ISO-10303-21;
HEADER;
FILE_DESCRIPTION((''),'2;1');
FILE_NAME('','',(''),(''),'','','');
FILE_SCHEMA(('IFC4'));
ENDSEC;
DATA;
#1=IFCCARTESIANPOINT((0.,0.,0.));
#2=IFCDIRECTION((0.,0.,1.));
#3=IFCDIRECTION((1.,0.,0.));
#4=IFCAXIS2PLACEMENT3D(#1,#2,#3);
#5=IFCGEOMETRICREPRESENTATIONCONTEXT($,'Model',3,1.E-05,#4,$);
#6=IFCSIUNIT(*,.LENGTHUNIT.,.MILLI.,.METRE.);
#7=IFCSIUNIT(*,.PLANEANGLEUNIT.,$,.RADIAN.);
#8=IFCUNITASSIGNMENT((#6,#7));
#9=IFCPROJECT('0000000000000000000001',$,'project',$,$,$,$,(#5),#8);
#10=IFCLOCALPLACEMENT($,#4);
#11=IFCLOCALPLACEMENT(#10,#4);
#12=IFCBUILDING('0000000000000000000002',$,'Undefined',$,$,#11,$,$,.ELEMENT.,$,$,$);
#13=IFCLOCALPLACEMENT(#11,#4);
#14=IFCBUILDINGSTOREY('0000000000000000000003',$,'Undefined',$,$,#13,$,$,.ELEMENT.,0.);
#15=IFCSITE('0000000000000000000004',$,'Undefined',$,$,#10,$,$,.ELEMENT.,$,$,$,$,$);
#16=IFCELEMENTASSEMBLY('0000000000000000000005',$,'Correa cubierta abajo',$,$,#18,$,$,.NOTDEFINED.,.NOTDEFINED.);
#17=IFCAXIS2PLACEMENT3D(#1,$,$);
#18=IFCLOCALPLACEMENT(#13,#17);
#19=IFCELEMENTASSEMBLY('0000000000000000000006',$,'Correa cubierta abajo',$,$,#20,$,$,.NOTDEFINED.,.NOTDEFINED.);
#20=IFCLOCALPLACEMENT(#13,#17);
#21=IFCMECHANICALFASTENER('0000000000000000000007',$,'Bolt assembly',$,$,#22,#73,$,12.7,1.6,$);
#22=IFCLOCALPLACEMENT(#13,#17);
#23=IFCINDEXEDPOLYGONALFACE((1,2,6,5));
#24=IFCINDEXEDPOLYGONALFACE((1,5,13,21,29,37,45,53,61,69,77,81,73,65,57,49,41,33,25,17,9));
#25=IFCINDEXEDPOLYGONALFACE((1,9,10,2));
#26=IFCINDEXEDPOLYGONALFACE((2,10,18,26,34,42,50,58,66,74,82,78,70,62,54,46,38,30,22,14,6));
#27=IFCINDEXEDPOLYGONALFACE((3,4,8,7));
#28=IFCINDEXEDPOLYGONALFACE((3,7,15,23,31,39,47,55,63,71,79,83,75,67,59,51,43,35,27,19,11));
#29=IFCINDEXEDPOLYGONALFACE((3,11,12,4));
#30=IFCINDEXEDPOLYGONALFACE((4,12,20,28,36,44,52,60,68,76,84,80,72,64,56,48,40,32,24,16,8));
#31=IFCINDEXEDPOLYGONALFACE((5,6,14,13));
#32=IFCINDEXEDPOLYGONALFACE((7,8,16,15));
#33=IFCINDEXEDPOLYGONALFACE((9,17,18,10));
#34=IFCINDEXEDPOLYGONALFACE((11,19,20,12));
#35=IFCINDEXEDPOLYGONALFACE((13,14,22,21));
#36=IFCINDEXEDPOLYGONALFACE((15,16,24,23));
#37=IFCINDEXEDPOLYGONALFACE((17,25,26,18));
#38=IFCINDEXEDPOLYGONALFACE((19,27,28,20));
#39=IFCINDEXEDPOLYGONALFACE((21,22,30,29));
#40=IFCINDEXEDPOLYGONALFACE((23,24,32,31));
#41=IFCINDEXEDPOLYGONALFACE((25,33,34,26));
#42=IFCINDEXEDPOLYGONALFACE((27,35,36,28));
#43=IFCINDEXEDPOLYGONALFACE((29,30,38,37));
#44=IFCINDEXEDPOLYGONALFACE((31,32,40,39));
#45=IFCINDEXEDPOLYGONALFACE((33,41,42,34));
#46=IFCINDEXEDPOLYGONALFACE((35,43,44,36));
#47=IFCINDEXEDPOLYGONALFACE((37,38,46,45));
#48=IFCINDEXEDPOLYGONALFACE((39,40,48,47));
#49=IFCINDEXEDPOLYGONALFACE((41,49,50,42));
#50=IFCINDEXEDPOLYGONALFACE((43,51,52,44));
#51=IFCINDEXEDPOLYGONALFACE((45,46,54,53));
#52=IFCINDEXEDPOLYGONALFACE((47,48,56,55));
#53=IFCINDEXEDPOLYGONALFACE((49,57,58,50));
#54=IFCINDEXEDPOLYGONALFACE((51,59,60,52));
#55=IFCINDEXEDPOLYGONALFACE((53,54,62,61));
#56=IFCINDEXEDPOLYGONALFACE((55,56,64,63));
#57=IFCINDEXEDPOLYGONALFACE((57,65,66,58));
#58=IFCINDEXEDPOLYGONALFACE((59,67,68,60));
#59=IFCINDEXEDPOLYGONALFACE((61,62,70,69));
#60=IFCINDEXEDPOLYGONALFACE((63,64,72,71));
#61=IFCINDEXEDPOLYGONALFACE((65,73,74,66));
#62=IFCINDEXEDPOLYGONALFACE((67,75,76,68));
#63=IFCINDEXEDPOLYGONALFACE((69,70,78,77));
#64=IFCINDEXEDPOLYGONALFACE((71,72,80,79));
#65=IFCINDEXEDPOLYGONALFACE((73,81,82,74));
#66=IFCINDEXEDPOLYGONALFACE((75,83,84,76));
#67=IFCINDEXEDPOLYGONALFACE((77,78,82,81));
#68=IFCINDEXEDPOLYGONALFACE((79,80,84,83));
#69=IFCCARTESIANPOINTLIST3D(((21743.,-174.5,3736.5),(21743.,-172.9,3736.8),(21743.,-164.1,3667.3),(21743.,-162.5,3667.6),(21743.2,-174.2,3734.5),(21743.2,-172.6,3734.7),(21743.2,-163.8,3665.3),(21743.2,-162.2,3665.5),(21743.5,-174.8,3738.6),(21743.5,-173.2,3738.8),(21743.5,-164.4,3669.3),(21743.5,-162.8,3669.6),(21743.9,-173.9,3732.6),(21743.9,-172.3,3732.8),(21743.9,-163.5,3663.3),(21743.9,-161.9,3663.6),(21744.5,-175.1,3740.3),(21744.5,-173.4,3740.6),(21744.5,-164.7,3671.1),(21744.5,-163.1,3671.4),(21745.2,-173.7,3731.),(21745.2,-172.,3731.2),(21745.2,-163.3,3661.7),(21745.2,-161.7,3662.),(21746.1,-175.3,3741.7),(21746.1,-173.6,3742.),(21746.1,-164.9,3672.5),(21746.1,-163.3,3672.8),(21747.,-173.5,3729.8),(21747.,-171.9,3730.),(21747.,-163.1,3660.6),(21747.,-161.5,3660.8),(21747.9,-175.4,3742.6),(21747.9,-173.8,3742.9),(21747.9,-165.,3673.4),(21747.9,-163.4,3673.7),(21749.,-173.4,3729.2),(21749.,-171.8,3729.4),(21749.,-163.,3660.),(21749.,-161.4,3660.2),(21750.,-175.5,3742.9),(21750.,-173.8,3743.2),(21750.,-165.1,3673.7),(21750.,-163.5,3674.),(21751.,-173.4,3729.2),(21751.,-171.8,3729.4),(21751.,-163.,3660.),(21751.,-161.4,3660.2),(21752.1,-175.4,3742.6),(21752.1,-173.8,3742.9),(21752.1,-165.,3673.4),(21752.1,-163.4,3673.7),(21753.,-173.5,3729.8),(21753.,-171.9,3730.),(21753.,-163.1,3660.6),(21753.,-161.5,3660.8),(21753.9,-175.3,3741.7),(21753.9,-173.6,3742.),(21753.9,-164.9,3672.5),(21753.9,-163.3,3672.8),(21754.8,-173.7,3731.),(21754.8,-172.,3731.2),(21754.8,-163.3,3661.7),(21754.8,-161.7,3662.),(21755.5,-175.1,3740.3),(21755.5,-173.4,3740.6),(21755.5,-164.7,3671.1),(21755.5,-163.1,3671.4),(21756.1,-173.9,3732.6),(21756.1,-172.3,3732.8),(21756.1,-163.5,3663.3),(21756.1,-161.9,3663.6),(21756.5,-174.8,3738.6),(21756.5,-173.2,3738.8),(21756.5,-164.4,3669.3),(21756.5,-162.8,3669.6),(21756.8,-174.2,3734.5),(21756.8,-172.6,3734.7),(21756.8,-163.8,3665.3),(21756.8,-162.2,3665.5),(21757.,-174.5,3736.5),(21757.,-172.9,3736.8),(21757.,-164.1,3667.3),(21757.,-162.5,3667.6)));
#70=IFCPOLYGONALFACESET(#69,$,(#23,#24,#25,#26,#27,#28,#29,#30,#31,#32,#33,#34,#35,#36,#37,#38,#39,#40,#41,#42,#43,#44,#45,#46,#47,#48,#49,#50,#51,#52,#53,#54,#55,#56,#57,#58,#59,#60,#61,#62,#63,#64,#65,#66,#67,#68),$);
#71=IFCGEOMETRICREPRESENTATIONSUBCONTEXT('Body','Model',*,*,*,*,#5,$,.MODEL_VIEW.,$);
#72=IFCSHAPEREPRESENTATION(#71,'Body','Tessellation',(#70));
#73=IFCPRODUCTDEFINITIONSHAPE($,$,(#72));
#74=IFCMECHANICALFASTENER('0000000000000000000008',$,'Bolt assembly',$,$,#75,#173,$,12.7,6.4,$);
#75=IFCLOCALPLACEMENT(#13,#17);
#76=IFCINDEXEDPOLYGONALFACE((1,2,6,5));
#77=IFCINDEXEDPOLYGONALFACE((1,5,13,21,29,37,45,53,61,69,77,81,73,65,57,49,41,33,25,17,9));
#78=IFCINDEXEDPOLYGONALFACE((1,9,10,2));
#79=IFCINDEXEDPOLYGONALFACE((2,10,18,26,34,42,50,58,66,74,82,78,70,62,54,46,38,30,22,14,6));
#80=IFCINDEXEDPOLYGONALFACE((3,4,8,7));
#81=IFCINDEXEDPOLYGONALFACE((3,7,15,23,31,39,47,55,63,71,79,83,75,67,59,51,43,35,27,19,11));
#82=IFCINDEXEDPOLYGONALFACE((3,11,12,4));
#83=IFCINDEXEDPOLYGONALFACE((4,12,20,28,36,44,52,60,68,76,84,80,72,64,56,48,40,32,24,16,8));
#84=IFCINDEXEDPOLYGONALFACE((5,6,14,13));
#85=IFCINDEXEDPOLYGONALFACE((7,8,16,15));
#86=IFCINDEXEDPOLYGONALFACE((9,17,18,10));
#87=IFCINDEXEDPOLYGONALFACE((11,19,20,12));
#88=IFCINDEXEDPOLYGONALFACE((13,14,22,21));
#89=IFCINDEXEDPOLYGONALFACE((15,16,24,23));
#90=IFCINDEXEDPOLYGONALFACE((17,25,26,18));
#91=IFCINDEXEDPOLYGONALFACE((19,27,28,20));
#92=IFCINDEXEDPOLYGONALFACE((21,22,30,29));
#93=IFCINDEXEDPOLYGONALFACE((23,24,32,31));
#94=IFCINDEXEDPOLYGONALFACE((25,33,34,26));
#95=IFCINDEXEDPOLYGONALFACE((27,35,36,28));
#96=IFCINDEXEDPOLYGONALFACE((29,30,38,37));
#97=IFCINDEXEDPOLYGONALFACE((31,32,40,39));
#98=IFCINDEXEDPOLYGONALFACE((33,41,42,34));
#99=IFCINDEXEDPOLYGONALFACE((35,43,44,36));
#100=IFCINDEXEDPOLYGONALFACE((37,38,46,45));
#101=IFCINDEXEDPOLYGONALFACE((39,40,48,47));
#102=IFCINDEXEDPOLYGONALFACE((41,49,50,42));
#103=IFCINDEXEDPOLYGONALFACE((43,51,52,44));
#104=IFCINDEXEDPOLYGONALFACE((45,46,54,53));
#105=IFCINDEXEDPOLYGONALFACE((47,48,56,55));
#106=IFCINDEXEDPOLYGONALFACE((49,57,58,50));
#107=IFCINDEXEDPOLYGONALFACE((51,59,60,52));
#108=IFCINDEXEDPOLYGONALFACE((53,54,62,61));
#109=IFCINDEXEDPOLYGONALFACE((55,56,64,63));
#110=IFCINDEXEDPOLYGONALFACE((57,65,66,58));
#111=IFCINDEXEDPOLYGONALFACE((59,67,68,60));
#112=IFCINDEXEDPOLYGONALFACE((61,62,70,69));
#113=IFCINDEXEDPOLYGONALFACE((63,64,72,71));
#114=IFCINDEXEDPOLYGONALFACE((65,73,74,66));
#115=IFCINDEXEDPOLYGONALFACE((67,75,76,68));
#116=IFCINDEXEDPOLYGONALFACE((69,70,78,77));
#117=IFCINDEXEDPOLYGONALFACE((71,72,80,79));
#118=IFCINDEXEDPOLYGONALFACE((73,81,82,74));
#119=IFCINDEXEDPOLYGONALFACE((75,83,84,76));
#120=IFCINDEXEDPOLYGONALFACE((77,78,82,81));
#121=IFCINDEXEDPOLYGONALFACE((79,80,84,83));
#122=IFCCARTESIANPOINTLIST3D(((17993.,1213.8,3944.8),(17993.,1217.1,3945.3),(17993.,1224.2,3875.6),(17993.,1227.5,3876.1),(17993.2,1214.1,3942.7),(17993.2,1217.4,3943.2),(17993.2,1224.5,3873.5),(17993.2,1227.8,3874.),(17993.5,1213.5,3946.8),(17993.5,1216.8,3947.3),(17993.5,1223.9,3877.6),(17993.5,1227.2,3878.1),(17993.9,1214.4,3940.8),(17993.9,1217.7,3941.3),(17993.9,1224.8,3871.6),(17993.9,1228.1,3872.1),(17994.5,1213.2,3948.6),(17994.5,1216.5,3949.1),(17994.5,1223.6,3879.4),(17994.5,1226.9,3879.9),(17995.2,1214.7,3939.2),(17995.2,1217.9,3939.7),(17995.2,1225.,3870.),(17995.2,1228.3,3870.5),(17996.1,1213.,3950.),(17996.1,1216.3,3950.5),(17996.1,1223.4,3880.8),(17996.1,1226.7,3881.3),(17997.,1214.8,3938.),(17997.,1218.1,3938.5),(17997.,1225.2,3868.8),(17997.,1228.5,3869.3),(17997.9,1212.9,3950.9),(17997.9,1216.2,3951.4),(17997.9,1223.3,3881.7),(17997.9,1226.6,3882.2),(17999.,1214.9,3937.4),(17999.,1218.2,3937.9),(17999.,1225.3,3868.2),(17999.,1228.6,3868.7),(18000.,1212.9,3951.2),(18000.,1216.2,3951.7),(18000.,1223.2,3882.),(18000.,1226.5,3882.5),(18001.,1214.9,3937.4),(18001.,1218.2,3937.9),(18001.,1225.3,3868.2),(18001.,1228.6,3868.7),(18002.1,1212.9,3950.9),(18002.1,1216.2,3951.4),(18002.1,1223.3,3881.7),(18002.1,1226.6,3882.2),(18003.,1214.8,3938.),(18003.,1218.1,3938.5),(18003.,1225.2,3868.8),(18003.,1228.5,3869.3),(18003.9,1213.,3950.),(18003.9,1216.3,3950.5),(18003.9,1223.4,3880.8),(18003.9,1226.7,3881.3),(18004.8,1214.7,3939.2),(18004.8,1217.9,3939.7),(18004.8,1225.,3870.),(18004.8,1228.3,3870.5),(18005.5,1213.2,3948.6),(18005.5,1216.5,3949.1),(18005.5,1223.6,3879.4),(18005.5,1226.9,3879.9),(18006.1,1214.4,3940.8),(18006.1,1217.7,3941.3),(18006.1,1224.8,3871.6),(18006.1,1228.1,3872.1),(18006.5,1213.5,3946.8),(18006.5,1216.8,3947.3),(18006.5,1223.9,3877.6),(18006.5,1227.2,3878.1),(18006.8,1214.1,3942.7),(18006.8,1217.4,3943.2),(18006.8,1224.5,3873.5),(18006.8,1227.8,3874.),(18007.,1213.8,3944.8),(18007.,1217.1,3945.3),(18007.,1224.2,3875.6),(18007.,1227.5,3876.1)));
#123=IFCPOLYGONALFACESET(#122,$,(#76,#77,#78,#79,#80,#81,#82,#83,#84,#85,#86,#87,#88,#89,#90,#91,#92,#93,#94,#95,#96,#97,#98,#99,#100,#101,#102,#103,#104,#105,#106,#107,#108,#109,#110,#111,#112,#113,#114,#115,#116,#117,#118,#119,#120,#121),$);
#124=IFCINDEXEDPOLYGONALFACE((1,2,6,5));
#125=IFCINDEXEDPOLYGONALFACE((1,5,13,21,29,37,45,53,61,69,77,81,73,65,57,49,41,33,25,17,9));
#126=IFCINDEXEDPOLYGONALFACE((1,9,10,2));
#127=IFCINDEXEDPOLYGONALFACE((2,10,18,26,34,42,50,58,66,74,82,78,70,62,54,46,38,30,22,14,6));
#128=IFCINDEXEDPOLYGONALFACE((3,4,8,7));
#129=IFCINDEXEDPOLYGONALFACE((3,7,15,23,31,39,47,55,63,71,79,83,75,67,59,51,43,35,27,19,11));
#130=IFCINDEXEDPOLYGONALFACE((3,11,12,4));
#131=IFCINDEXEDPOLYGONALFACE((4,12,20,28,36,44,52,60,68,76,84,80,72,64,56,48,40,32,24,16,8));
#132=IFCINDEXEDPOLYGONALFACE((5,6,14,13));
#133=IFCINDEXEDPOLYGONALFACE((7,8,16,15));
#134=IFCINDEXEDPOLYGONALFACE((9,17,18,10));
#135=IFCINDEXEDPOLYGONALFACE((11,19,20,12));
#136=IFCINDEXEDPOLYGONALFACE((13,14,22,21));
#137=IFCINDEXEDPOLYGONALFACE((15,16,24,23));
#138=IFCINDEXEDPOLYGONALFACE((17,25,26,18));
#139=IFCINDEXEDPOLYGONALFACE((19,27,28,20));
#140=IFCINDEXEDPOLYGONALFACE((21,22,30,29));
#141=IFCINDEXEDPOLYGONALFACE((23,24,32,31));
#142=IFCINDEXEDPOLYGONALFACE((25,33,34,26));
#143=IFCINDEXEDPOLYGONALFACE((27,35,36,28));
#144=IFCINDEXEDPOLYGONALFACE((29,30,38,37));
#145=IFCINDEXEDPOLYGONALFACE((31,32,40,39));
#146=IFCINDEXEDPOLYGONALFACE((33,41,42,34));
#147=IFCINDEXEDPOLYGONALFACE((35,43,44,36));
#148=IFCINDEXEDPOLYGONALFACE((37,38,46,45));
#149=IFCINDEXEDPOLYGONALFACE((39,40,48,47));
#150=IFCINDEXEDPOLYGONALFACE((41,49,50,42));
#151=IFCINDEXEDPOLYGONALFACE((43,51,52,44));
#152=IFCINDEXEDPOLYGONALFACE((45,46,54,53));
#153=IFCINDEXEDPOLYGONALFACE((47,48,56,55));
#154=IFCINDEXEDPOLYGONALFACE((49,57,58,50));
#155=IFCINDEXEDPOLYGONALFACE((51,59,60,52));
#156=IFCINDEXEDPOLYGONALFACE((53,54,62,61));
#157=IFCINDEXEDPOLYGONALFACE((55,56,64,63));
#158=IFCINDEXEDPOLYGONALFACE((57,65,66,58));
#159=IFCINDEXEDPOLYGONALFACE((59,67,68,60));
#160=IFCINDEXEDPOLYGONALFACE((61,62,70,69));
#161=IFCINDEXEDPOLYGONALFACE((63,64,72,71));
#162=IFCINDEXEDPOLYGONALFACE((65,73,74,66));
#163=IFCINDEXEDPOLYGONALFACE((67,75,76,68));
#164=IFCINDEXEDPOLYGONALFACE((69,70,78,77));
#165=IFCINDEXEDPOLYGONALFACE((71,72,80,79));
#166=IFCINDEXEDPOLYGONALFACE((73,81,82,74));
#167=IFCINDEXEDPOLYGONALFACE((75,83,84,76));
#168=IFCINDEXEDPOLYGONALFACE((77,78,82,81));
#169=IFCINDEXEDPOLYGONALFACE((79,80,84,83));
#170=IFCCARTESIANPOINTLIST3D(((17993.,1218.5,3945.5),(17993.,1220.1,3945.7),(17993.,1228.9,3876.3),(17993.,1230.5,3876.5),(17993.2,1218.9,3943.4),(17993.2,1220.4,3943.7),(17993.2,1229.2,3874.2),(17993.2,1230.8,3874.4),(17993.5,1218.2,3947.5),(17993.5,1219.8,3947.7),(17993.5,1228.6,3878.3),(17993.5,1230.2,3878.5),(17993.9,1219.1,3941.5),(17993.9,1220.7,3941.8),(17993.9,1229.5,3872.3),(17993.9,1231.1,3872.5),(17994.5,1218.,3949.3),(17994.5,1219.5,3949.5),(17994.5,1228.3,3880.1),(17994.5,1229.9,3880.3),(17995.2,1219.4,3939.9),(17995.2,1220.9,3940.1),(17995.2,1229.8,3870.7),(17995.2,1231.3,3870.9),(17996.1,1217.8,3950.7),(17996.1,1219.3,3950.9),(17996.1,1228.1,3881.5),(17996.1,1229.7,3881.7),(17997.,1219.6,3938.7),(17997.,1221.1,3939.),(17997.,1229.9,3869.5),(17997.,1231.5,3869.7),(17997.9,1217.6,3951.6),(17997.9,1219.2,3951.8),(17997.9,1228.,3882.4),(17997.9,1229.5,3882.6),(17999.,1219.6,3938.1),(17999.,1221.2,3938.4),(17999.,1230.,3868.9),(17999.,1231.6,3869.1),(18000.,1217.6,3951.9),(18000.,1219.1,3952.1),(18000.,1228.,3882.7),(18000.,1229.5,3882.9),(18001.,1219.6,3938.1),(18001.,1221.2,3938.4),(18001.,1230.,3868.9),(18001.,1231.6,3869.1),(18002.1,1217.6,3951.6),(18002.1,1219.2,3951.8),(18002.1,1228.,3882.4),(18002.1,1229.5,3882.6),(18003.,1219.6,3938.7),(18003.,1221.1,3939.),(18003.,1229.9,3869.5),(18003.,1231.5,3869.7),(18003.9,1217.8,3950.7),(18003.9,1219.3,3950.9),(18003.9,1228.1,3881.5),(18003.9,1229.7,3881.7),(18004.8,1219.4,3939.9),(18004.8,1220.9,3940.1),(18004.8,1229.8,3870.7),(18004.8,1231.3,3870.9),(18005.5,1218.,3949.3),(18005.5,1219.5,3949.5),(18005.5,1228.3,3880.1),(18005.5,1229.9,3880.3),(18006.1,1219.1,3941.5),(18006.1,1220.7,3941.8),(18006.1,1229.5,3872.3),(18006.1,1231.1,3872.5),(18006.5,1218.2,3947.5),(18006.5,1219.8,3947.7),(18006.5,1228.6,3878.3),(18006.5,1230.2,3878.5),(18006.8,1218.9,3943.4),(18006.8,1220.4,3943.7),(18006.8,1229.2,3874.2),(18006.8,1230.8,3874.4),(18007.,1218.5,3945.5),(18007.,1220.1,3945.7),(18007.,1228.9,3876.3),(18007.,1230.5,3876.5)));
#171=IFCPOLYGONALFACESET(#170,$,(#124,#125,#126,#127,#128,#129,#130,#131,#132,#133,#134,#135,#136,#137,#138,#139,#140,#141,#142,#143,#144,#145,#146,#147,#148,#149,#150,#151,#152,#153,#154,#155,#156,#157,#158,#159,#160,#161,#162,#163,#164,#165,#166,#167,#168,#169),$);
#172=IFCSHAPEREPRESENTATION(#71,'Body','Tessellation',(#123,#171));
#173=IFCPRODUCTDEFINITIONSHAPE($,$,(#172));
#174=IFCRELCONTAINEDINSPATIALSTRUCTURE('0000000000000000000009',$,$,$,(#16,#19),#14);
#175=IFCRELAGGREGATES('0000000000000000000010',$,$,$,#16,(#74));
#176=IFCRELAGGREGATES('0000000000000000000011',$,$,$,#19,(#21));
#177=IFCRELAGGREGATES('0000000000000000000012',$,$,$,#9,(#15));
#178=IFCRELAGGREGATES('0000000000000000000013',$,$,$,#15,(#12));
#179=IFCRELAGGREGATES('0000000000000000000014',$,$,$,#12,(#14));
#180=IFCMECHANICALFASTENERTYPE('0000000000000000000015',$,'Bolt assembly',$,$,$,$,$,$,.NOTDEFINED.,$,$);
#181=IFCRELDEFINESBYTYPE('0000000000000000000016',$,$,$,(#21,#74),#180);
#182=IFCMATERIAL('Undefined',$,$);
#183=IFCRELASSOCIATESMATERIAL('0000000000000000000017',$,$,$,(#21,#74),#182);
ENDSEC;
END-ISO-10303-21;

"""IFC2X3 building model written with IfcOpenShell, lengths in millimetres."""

from ifc_helpers import new_model, si_unit, frame, origin_with_axes, origin_2d_with_axis, place, context, subcontext, project, spatial, circle, extrude, source, transform, mapped, material, type_object, element, aggregate, save


model = new_model("IFC2X3")

# Units and contexts
model_context = context("Model", 3, precision=1e-05, world=origin_with_axes())
body_context = subcontext(model_context, "Body", "Model", "MODEL_VIEW")
ifc_project = project(units=[si_unit("LENGTHUNIT", "METRE", prefix="MILLI"), si_unit("PLANEANGLEUNIT", "RADIAN")], contexts=[model_context])

# Site, building, storey
site_placement = place(None, origin_with_axes())
site = spatial("IfcSite", under=ifc_project, at=site_placement, Name="Undefined", CompositionType="ELEMENT")
building_placement = place(site_placement, origin_with_axes())
building = spatial("IfcBuilding", under=site, at=building_placement, Name="Undefined", CompositionType="ELEMENT")
storey_placement = place(building_placement, origin_with_axes())
storey = spatial("IfcBuildingStorey", under=building, at=storey_placement, Name="Undefined", CompositionType="ELEMENT", Elevation=0.0)

# Element assemblies
assembly_1_placement = place(storey_placement, origin_with_axes())
assembly_1 = element("IfcElementAssembly", 1, at=assembly_1_placement, inside=storey, Name="Correa cubierta abajo", AssemblyPlace="NOTDEFINED", PredefinedType="NOTDEFINED")
ifc_material_1 = material(Name="Undefined")
mechanical_fastener_type = type_object("IfcMechanicalFastenerType", Name="Bolt assembly")
assembly_2_placement = place(storey_placement, origin_with_axes())
assembly_2 = element("IfcElementAssembly", 2, at=assembly_2_placement, inside=storey, Name="Correa cubierta abajo", AssemblyPlace="NOTDEFINED", PredefinedType="NOTDEFINED")

# Mechanical fasteners
shared_shape_1 = source(origin_with_axes(), body_context, "Body", "SweptSolid", [
    extrude(circle(Radius=7.0, at=origin_2d_with_axis()), frame((0.0, 3.2, 0.0), z_axis=(0.0, 1.0, 0.0), x_axis=(1.0, 0.0, 0.0)), (0.0, 0.0, 1.0), 1.7),
])
mechanical_fastener_1_placement = place(assembly_2_placement, frame((21750.0, -159.3, 3667.5), z_axis=(1.0, 0.0, 0.0), x_axis=(0.0, -0.148209, 0.988956)))
mechanical_fastener_1 = element("IfcMechanicalFastener", 3, at=mechanical_fastener_1_placement, type_object=mechanical_fastener_type, material=ifc_material_1, Name="Bolt assembly", NominalDiameter=12.7, NominalLength=1.6, context=body_context, shape_type="MappedRepresentation", body=[
    mapped(shared_shape_1, transform((0.0, 0.0, 0.0))),
    mapped(shared_shape_1, transform((70.0, 0.0, 0.0))),
])
shared_shape_2 = source(origin_with_axes(), body_context, "Body", "SweptSolid", [
    extrude(circle(Radius=7.0, at=origin_2d_with_axis()), frame((0.0, 6.3, 0.0), z_axis=(0.0, 1.0, 0.0), x_axis=(1.0, 0.0, 0.0)), (0.0, 0.0, 1.0), 3.3),
    extrude(circle(Radius=7.0, at=origin_2d_with_axis()), frame((0.0, 3.3, 0.0), z_axis=(0.0, 1.0, 0.0), x_axis=(1.0, 0.0, 0.0)), (0.0, 0.0, 1.0), 1.6),
])
mechanical_fastener_2_placement = place(assembly_1_placement, frame((18000.0, 1233.8, 3876.5), z_axis=(1.0, 0.0, 0.0), x_axis=(0.0, -0.148209, 0.988956)))
mechanical_fastener_2 = element("IfcMechanicalFastener", 4, at=mechanical_fastener_2_placement, type_object=mechanical_fastener_type, material=ifc_material_1, Name="Bolt assembly", NominalDiameter=12.7, NominalLength=6.4, context=body_context, shape_type="MappedRepresentation", body=[
    mapped(shared_shape_2, transform((0.0, 0.0, 0.0))),
    mapped(shared_shape_2, transform((70.0, 0.0, 0.0))),
])
aggregate(assembly_1, [mechanical_fastener_2])
aggregate(assembly_2, [mechanical_fastener_1])

save(model, "model.ifc")
